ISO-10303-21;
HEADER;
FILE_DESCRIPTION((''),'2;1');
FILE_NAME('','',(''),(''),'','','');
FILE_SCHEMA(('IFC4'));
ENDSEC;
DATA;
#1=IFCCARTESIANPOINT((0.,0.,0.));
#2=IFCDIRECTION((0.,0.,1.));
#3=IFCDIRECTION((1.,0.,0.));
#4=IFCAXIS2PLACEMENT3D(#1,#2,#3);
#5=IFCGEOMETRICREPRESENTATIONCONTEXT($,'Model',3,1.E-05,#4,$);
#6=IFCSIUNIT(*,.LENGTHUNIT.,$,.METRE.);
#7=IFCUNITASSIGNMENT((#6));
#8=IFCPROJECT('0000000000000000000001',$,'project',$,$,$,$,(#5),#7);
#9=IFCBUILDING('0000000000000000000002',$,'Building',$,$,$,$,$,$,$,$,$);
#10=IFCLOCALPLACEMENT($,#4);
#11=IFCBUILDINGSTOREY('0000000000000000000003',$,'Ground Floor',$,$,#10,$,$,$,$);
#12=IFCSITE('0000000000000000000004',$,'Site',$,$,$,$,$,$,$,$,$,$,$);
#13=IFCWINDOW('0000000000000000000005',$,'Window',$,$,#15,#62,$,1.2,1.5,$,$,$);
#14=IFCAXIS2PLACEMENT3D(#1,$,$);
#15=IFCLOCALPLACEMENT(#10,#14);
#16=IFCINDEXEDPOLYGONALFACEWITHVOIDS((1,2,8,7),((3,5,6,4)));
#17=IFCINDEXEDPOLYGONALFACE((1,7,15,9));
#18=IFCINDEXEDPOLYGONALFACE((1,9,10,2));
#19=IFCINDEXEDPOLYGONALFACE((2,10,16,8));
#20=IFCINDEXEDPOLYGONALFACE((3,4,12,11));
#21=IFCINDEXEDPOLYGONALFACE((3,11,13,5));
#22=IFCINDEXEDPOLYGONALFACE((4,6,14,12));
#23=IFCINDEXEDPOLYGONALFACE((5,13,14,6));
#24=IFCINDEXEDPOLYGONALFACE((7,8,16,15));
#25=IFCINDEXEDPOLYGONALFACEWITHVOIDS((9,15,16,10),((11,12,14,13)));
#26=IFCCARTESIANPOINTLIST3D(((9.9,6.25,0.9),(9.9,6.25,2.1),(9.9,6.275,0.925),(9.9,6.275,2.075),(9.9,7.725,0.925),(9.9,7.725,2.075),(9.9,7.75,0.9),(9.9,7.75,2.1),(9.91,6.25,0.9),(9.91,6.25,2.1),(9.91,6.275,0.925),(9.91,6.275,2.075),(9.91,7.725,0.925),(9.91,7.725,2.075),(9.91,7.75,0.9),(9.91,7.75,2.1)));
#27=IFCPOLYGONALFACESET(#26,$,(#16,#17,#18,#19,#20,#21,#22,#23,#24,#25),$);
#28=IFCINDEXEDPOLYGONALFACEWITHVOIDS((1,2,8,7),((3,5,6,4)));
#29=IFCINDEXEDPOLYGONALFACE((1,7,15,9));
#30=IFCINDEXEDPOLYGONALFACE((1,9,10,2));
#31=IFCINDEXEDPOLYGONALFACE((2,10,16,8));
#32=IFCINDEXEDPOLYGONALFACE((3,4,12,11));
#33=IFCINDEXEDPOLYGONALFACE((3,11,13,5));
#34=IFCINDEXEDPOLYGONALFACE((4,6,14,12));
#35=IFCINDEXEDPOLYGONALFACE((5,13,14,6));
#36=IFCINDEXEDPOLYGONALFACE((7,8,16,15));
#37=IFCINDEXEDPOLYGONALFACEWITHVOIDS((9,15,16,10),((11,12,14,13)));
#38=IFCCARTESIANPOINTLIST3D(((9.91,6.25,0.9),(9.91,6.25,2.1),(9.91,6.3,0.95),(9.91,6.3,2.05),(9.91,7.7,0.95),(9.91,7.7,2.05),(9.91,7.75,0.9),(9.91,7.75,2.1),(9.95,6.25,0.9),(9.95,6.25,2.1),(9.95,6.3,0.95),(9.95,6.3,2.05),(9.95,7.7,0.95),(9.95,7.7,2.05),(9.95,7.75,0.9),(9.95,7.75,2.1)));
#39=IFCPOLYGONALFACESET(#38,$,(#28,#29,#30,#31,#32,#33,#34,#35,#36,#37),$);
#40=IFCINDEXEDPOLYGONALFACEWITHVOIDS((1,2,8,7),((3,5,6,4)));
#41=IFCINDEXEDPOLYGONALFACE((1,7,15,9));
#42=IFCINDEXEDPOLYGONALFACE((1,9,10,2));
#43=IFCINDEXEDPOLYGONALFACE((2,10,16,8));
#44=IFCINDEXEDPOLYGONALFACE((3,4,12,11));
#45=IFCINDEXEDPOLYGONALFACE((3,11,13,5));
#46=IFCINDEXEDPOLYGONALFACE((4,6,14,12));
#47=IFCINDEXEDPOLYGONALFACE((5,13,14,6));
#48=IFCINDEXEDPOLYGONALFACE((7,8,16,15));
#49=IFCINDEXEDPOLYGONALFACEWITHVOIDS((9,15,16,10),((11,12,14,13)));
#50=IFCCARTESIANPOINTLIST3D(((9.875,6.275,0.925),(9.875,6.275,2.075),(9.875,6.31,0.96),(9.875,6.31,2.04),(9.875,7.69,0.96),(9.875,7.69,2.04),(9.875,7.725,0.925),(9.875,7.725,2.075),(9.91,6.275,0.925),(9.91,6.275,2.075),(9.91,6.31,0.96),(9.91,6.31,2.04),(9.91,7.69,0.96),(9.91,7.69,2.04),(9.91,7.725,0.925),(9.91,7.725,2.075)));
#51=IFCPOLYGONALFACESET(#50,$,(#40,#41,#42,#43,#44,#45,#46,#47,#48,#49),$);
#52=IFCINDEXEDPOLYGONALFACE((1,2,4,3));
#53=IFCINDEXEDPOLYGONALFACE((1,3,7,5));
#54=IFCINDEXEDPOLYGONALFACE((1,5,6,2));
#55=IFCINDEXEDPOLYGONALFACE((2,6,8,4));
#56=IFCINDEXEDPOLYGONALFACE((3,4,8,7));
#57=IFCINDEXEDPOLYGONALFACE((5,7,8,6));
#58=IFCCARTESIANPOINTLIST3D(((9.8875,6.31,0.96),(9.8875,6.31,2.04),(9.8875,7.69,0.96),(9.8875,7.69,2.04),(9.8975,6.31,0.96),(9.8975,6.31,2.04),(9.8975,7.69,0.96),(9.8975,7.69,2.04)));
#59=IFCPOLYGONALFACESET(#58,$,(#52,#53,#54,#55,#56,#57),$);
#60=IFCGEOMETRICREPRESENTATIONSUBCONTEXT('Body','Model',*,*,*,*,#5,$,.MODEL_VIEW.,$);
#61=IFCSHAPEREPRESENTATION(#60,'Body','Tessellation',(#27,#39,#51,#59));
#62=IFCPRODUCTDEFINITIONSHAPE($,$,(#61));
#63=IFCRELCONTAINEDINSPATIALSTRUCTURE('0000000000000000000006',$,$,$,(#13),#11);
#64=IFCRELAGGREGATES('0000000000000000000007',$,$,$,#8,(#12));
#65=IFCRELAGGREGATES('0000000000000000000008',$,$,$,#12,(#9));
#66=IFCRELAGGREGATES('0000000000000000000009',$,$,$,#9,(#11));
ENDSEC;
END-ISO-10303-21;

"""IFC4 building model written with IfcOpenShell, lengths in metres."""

from ifc_helpers import new_model, si_unit, frame, origin_with_axes, place, context, subcontext, project, spatial, line, indexed_curve, outline, extrude, element, save


model = new_model("IFC4")

# Units and contexts
model_context = context("Model", 3, precision=1e-05, world=origin_with_axes())
body_context = subcontext(model_context, "Body", "Model", "MODEL_VIEW")
ifc_project = project(units=[si_unit("LENGTHUNIT", "METRE")], contexts=[model_context])

# Site, building, storey
site = spatial("IfcSite", under=ifc_project, Name="Site")
building = spatial("IfcBuilding", under=site, Name="Building")
storey_placement = place(None, origin_with_axes())
storey = spatial("IfcBuildingStorey", under=building, at=storey_placement, Name="Ground Floor")

# Window
for number, where, z_axis, x_axis, name in (
    (1, (10.0, 6.25, 0.9), (0.0, 0.0, 1.0), (0.0, 1.0, 0.0), "Window"),
):
    element("IfcWindow", number, at=place(storey_placement, frame(where, z_axis=z_axis, x_axis=x_axis)), inside=storey, Name=name, OverallHeight=1.2, OverallWidth=1.5, context=body_context, shape_type="SweptSolid", body=[
        extrude(outline(indexed_curve([(0.0, 0.0), (1.5, 0.0), (1.5, 1.2), (0.0, 1.2)], segments=[line(1, 2, 3, 4, 1)]), holes=[indexed_curve([(0.025, 0.025), (1.475, 0.025), (1.475, 1.175), (0.025, 1.175)], segments=[line(1, 2, 3, 4, 1)])]), frame((0.0, 0.09, 0.0), z_axis=(0.0, -1.0, 0.0), x_axis=(1.0, 0.0, 0.0)), (0.0, 0.0, -1.0), 0.01),
        extrude(outline(indexed_curve([(0.0, 0.0), (1.5, 0.0), (1.5, 1.2), (0.0, 1.2)], segments=[line(1, 2, 3, 4, 1)]), holes=[indexed_curve([(0.05, 0.05), (1.45, 0.05), (1.45, 1.15), (0.05, 1.15)], segments=[line(1, 2, 3, 4, 1)])]), frame((0.0, 0.05, 0.0), z_axis=(0.0, -1.0, 0.0), x_axis=(1.0, 0.0, 0.0)), (0.0, 0.0, -1.0), 0.04),
        extrude(outline(indexed_curve([(0.0, 0.0), (1.45, 0.0), (1.45, 1.15), (0.0, 1.15)], segments=[line(1, 2, 3, 4, 1)]), holes=[indexed_curve([(0.035, 0.035), (1.415, 0.035), (1.415, 1.115), (0.035, 1.115)], segments=[line(1, 2, 3, 4, 1)])]), frame((0.025, 0.09, 0.025), z_axis=(0.0, -1.0, 0.0), x_axis=(1.0, 0.0, 0.0)), (0.0, 0.0, -1.0), 0.035),
        extrude(outline(indexed_curve([(0.035, 0.035), (1.415, 0.035), (1.415, 1.115), (0.035, 1.115)], segments=[line(1, 2, 3, 4, 1)])), frame((0.025, 0.1025, 0.025), z_axis=(0.0, -1.0, 0.0), x_axis=(1.0, 0.0, 0.0)), (0.0, 0.0, -1.0), 0.01),
    ])

save(model, "model.ifc")
